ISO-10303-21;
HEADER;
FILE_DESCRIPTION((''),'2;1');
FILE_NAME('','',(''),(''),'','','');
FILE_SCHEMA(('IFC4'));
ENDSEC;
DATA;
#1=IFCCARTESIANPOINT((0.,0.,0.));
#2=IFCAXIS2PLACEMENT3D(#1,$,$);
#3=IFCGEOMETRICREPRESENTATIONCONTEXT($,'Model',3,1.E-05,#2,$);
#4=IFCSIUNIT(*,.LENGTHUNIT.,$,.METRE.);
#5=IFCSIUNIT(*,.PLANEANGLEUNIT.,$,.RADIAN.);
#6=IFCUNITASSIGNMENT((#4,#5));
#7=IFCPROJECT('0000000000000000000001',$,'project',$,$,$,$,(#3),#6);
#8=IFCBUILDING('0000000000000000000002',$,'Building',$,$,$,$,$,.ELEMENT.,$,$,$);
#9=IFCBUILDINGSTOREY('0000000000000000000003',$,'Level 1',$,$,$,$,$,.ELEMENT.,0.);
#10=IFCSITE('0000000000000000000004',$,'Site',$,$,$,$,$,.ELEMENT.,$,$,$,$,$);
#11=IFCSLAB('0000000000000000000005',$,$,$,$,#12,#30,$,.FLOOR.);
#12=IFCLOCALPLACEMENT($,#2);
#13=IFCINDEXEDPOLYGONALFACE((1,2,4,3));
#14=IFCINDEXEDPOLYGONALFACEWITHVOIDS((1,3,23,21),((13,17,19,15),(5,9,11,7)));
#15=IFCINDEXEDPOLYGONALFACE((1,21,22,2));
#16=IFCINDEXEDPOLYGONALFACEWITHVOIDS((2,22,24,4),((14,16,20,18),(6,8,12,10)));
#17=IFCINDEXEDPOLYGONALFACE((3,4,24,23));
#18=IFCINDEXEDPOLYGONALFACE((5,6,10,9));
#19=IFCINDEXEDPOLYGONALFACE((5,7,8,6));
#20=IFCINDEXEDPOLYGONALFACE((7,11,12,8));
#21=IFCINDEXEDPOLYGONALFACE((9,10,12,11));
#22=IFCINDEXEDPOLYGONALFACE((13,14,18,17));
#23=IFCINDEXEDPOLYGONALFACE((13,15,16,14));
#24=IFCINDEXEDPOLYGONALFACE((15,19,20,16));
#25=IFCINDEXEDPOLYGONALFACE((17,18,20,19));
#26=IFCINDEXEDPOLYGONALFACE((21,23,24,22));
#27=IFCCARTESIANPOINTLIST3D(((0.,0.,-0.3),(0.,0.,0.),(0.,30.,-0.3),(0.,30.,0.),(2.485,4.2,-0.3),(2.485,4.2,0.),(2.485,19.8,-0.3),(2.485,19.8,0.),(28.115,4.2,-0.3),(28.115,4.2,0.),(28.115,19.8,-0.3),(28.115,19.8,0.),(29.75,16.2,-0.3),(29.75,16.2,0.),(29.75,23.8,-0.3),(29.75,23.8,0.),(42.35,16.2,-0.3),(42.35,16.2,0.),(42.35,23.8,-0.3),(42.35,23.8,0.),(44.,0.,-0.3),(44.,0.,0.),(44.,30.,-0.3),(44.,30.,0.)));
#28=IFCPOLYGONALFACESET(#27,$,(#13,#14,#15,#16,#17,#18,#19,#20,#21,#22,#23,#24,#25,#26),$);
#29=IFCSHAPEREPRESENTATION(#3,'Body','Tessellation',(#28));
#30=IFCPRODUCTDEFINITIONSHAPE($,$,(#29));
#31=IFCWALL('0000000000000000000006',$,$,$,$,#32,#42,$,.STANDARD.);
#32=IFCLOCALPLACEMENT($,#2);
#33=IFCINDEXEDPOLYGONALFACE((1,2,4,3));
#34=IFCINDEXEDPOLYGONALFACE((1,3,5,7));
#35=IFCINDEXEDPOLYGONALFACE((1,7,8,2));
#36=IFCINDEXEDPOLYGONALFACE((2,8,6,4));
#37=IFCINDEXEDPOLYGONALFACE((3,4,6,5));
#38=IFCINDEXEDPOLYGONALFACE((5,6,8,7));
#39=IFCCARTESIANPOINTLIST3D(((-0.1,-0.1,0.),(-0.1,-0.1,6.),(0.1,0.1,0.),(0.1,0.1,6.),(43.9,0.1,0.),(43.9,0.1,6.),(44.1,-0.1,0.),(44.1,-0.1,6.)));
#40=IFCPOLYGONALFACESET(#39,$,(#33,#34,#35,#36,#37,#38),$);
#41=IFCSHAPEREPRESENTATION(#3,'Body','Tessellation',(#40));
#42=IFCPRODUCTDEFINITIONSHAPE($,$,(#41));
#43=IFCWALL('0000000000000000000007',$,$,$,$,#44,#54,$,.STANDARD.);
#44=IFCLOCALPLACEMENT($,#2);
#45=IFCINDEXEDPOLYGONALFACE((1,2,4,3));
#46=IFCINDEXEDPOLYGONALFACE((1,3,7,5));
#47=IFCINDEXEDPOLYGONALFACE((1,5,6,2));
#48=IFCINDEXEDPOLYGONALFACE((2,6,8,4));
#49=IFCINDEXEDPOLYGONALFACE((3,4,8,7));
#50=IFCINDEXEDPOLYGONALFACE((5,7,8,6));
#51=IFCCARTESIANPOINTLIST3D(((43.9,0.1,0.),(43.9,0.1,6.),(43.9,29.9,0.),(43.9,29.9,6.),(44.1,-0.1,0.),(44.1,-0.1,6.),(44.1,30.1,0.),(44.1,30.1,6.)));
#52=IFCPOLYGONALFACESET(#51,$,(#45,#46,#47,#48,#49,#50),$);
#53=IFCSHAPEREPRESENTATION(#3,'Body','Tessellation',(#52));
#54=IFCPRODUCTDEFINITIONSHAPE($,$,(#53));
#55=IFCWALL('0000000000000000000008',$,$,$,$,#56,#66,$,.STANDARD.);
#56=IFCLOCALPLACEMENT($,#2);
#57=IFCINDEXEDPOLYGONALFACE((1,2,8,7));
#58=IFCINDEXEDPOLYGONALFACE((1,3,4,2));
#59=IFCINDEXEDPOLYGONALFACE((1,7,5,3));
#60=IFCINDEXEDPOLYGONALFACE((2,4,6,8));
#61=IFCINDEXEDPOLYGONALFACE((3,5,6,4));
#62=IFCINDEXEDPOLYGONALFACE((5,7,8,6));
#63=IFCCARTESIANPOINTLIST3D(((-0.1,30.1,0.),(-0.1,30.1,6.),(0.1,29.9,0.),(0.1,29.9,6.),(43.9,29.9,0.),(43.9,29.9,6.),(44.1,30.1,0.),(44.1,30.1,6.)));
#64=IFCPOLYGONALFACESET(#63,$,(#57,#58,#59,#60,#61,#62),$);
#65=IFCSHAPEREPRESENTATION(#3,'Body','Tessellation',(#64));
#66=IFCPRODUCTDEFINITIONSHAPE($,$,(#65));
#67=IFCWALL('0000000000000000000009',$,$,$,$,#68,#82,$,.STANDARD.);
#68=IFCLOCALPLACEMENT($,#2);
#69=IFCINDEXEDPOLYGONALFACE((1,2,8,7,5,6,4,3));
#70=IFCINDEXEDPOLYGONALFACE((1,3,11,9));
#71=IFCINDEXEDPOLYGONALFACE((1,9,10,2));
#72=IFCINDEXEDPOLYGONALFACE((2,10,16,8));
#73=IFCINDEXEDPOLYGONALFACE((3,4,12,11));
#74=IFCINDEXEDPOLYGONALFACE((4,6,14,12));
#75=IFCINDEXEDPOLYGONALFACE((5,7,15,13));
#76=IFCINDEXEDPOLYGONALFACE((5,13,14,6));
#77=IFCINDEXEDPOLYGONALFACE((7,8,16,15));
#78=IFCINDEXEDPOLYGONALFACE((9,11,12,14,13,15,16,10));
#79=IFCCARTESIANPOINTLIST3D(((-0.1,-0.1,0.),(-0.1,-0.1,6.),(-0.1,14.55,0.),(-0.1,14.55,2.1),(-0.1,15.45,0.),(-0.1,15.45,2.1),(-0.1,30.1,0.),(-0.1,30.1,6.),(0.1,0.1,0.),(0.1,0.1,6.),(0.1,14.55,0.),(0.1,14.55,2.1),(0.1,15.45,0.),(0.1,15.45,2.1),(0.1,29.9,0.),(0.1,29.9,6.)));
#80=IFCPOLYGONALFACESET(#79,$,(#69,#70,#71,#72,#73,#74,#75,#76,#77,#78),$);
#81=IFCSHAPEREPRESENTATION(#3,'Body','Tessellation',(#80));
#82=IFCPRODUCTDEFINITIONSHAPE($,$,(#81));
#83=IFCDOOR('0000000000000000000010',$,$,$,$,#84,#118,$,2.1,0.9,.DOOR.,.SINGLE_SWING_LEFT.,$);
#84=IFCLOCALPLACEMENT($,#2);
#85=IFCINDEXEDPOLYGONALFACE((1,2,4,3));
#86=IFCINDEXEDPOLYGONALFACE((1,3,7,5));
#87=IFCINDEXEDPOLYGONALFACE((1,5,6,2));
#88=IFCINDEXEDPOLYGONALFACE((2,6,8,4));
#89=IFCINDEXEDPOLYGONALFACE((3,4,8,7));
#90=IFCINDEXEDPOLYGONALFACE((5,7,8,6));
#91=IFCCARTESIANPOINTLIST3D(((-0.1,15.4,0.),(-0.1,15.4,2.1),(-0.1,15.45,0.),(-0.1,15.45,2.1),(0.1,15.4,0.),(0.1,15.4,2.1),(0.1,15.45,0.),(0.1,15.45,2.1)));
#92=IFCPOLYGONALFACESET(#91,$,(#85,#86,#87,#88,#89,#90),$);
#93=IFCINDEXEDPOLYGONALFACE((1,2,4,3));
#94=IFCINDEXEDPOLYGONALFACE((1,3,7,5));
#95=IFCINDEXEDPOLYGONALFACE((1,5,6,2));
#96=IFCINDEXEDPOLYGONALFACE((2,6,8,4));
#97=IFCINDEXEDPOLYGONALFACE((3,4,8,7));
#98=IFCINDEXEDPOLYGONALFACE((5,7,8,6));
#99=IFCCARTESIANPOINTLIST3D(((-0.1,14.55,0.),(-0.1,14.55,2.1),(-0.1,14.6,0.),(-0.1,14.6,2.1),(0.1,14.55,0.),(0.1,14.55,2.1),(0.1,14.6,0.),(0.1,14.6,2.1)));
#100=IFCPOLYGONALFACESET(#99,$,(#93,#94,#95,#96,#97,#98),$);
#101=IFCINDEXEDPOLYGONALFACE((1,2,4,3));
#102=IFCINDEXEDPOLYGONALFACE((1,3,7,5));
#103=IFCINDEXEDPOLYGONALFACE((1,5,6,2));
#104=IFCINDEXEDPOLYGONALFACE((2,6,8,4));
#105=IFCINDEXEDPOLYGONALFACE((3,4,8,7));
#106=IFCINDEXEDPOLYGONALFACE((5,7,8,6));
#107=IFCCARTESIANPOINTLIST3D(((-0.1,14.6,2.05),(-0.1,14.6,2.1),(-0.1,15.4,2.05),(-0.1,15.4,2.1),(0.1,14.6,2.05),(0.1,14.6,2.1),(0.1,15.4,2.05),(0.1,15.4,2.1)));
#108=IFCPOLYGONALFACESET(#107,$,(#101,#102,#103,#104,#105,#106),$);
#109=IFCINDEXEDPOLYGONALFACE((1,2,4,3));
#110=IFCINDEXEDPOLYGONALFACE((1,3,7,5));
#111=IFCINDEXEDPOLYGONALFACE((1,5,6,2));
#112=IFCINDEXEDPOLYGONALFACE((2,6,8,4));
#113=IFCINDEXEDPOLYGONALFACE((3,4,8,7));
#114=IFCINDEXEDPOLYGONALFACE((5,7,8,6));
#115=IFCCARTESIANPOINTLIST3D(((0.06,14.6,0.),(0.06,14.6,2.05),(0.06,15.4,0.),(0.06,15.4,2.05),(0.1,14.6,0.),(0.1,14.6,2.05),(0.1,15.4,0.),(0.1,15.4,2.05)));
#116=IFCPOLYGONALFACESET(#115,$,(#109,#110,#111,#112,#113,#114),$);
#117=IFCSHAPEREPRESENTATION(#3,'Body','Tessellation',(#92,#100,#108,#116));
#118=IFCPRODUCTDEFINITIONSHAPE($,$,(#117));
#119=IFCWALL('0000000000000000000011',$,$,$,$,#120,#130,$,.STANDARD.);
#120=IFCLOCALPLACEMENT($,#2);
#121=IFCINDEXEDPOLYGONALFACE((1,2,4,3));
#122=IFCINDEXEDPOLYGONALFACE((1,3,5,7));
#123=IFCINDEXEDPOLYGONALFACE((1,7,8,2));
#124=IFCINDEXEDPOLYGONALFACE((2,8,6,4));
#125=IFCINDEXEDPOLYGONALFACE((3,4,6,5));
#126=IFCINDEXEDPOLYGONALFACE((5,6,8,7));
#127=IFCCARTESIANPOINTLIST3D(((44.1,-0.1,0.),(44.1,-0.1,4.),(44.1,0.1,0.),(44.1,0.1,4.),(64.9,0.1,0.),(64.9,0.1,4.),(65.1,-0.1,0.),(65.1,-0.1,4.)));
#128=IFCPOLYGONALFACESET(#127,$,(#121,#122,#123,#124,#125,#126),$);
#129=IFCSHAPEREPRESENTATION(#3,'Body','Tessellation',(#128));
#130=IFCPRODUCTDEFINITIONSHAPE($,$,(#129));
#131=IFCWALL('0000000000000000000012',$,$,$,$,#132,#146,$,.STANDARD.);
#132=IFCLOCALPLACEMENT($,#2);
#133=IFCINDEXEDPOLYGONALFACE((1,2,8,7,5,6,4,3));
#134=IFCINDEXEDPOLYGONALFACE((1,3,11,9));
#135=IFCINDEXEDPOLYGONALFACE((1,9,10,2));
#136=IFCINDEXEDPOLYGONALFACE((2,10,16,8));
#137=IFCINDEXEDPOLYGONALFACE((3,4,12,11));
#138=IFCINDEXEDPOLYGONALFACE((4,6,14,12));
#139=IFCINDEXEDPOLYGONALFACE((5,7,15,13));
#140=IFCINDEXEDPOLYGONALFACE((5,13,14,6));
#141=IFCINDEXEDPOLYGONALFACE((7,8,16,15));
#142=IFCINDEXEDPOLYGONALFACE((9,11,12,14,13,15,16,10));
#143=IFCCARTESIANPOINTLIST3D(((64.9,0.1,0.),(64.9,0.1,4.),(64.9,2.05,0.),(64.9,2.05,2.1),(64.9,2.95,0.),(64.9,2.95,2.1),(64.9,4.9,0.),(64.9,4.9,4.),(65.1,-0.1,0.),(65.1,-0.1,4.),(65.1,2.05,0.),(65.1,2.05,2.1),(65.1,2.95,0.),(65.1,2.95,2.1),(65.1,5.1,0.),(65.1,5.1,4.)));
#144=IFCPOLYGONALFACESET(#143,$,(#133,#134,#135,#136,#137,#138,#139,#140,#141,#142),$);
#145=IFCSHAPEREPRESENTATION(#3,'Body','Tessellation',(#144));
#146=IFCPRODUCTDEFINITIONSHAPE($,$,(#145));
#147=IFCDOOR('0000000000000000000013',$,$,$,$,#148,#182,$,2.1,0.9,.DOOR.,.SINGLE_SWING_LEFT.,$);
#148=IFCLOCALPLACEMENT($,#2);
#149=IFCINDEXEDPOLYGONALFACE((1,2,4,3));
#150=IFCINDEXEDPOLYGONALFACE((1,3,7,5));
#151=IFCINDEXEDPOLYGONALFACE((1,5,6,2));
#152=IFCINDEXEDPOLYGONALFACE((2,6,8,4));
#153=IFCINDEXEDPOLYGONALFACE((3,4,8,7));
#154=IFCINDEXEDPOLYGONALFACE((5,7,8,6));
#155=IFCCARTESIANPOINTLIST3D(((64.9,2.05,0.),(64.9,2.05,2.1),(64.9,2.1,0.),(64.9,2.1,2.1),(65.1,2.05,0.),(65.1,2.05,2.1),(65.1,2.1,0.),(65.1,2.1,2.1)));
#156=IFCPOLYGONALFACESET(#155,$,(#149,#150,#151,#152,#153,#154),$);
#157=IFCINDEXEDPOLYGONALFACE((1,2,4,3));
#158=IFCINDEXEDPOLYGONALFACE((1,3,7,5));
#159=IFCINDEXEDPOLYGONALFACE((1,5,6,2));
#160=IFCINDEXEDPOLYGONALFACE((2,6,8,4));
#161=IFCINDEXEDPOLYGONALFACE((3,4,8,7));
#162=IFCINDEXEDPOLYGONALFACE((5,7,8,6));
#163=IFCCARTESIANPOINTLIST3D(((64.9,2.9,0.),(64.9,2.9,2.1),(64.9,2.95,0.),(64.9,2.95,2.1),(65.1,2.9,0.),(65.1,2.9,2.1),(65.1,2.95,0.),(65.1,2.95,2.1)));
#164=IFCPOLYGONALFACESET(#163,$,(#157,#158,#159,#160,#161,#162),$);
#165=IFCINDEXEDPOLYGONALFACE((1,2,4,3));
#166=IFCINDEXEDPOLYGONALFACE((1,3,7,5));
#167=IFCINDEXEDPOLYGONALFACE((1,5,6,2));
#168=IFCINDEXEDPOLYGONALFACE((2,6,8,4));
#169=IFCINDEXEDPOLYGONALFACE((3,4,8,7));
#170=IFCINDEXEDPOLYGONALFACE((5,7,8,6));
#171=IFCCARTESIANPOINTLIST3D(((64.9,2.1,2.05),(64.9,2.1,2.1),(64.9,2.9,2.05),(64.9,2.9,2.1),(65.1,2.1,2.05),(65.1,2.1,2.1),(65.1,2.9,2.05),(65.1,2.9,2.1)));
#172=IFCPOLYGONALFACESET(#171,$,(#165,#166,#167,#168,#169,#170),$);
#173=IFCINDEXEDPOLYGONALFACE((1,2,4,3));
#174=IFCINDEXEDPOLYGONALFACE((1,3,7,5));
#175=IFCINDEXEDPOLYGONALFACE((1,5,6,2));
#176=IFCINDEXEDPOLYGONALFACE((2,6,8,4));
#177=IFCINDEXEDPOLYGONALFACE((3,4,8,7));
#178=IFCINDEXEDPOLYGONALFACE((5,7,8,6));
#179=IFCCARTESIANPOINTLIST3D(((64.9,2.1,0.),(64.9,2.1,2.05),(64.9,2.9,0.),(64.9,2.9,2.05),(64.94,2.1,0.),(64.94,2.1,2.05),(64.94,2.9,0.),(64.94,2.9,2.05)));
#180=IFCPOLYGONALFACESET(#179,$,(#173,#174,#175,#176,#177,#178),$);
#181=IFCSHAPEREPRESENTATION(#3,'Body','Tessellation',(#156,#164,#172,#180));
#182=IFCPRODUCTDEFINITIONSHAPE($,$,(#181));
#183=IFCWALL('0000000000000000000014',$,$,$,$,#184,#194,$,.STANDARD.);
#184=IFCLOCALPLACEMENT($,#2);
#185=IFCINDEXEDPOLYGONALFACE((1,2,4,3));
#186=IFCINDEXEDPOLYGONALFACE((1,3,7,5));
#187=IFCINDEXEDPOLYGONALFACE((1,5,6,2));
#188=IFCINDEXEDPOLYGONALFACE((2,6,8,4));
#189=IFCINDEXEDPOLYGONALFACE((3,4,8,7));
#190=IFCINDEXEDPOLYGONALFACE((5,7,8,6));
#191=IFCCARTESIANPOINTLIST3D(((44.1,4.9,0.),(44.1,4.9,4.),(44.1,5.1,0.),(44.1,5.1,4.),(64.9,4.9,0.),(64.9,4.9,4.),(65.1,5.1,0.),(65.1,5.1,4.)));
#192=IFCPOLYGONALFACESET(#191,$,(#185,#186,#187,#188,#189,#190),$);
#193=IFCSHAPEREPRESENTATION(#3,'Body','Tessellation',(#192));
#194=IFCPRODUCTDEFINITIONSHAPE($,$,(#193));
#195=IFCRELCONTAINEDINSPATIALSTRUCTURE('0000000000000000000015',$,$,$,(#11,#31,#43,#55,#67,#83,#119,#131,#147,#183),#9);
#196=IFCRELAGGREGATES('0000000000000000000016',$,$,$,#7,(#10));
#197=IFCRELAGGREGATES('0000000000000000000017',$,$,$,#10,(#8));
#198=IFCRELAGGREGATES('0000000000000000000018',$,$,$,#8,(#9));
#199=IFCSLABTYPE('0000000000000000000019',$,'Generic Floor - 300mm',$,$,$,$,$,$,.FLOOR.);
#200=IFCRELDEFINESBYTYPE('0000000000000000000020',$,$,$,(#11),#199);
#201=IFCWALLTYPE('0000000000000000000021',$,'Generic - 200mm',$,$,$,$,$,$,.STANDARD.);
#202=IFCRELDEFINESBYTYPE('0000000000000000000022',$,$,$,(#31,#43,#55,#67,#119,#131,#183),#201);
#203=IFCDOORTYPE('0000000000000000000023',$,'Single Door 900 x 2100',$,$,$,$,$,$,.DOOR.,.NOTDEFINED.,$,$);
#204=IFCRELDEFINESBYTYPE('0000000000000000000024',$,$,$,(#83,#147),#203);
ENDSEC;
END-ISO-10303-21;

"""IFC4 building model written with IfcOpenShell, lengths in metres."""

from ifc_helpers import new_model, si_unit, frame, frame_2d, origin, origin_with_axes, origin_2d, place, context, project, spatial, polyline, rectangle, outline, extrude, type_object, element, fill, save


model = new_model("IFC4")

# Units and contexts
model_context = context("Model", 3, precision=1e-05, world=origin())
ifc_project = project(units=[si_unit("LENGTHUNIT", "METRE"), si_unit("PLANEANGLEUNIT", "RADIAN")], contexts=[model_context])

# Site, building, storey
site = spatial("IfcSite", under=ifc_project, Name="Site", CompositionType="ELEMENT")
building = spatial("IfcBuilding", under=site, Name="Building", CompositionType="ELEMENT")
storey = spatial("IfcBuildingStorey", under=building, Name="Level 1", CompositionType="ELEMENT", Elevation=0.0)

# Slab, openings
slab_type = type_object("IfcSlabType", Name="Generic Floor - 300mm", PredefinedType="FLOOR")
slab_placement = place(None, origin())
slab = element("IfcSlab", 1, at=slab_placement, inside=storey, type_object=slab_type, PredefinedType="FLOOR", context=model_context, shape_type="SweptSolid", body=[
    extrude(outline(polyline([(0.0, 0.0), (44.0, 0.0), (44.0, 30.0), (0.0, 30.0), (0.0, 0.0)])), origin(), (0.0, 0.0, -1.0), 0.3),
])
opening_1_placement = place(None, frame((0.0, 0.0, 0.001)))
element("IfcOpeningElement", 2, at=opening_1_placement, cuts=slab, PredefinedType="OPENING", context=model_context, shape_type="SweptSolid", body=[
    extrude(outline(polyline([(2.485, 19.8), (2.485, 4.2), (28.115, 4.2), (28.115, 19.8), (2.485, 19.8)])), origin(), (0.0, 0.0, -1.0), 0.302),
])
opening_2_placement = place(None, frame((0.0, 0.0, 0.001)))
element("IfcOpeningElement", 3, at=opening_2_placement, cuts=slab, PredefinedType="OPENING", context=model_context, shape_type="SweptSolid", body=[
    extrude(outline(polyline([(29.75, 23.8), (29.75, 16.2), (42.35, 16.2), (42.35, 23.8), (29.75, 23.8)])), origin(), (0.0, 0.0, -1.0), 0.302),
])

# Walls
wall_type = type_object("IfcWallType", Name="Generic - 200mm", PredefinedType="STANDARD")
wall_1_placement = place(None, origin_with_axes())
element("IfcWall", 4, at=wall_1_placement, inside=storey, type_object=wall_type, PredefinedType="STANDARD", context=model_context, shape_type="SweptSolid", body=[
    extrude(outline(polyline([(-0.1, -0.1), (44.1, -0.1), (43.9, 0.1), (0.1, 0.1), (-0.1, -0.1)])), origin(), (0.0, 0.0, 1.0), 6.0),
])
wall_2_placement = place(None, frame((44.0, 0.0, 0.0), z_axis=(0.0, 0.0, 1.0), x_axis=(0.0, 1.0, 0.0)))
element("IfcWall", 5, at=wall_2_placement, inside=storey, type_object=wall_type, PredefinedType="STANDARD", context=model_context, shape_type="SweptSolid", body=[
    extrude(outline(polyline([(-0.1, -0.1), (30.1, -0.1), (29.9, 0.1), (0.1, 0.1), (-0.1, -0.1)])), origin(), (0.0, 0.0, 1.0), 6.0),
])
wall_3_placement = place(None, frame((44.0, 30.0, 0.0), z_axis=(0.0, 0.0, 1.0), x_axis=(-1.0, 0.0, 0.0)))
element("IfcWall", 6, at=wall_3_placement, inside=storey, type_object=wall_type, PredefinedType="STANDARD", context=model_context, shape_type="SweptSolid", body=[
    extrude(outline(polyline([(-0.1, -0.1), (44.1, -0.1), (43.9, 0.1), (0.1, 0.1), (-0.1, -0.1)])), origin(), (0.0, 0.0, 1.0), 6.0),
])

# Wall, opening, door
wall_4_placement = place(None, frame((0.0, 30.0, 0.0), z_axis=(0.0, 0.0, 1.0), x_axis=(0.0, -1.0, 0.0)))
wall_4 = element("IfcWall", 7, at=wall_4_placement, inside=storey, type_object=wall_type, PredefinedType="STANDARD", context=model_context, shape_type="SweptSolid", body=[
    extrude(outline(polyline([(-0.1, -0.1), (30.1, -0.1), (29.9, 0.1), (0.1, 0.1), (-0.1, -0.1)])), origin(), (0.0, 0.0, 1.0), 6.0),
])
opening_3_placement = place(wall_4_placement, frame((15.0, 0.0, 0.0), z_axis=(0.0, 0.0, 1.0), x_axis=(1.0, 0.0, 0.0)))
opening_3 = element("IfcOpeningElement", 8, at=opening_3_placement, cuts=wall_4, PredefinedType="OPENING", context=model_context, shape_type="SweptSolid", body=[
    extrude(rectangle(XDim=0.9, YDim=0.202, at=origin_2d()), origin(), (0.0, 0.0, 1.0), 2.1),
])
door_type = type_object("IfcDoorType", Name="Single Door 900 x 2100", OperationType="NOTDEFINED", PredefinedType="DOOR")
door_1_placement = place(opening_3_placement, origin_with_axes())
door_1 = element("IfcDoor", 9, at=door_1_placement, inside=storey, type_object=door_type, OperationType="SINGLE_SWING_LEFT", OverallHeight=2.1, OverallWidth=0.9, PredefinedType="DOOR", context=model_context, shape_type="SweptSolid", body=[
    extrude(rectangle(XDim=0.05, YDim=0.2, at=frame_2d((-0.425, 0.0))), origin(), (0.0, 0.0, 1.0), 2.1),
    extrude(rectangle(XDim=0.05, YDim=0.2, at=frame_2d((0.425, 0.0))), origin(), (0.0, 0.0, 1.0), 2.1),
    extrude(rectangle(XDim=0.8, YDim=0.2, at=origin_2d()), frame((0.0, 0.0, 2.05)), (0.0, 0.0, 1.0), 0.05),
    extrude(rectangle(XDim=0.8, YDim=0.04, at=frame_2d((0.0, 0.08))), origin(), (0.0, 0.0, 1.0), 2.05),
])
fill(opening_3, door_1)

# Wall
wall_5_placement = place(None, frame((44.1, 0.0, 0.0), z_axis=(0.0, 0.0, 1.0), x_axis=(1.0, 0.0, 0.0)))
element("IfcWall", 10, at=wall_5_placement, inside=storey, type_object=wall_type, PredefinedType="STANDARD", context=model_context, shape_type="SweptSolid", body=[
    extrude(outline(polyline([(0.0, -0.1), (21.0, -0.1), (20.8, 0.1), (0.0, 0.1), (0.0, -0.1)])), origin(), (0.0, 0.0, 1.0), 4.0),
])

# Wall, opening, door
wall_6_placement = place(None, frame((65.0, 0.0, 0.0), z_axis=(0.0, 0.0, 1.0), x_axis=(0.0, 1.0, 0.0)))
wall_6 = element("IfcWall", 11, at=wall_6_placement, inside=storey, type_object=wall_type, PredefinedType="STANDARD", context=model_context, shape_type="SweptSolid", body=[
    extrude(outline(polyline([(-0.1, -0.1), (5.1, -0.1), (4.9, 0.1), (0.1, 0.1), (-0.1, -0.1)])), origin(), (0.0, 0.0, 1.0), 4.0),
])
opening_4_placement = place(wall_6_placement, frame((2.5, 0.0, 0.0), z_axis=(0.0, 0.0, 1.0), x_axis=(1.0, 0.0, 0.0)))
opening_4 = element("IfcOpeningElement", 12, at=opening_4_placement, cuts=wall_6, PredefinedType="OPENING", context=model_context, shape_type="SweptSolid", body=[
    extrude(rectangle(XDim=0.9, YDim=0.202, at=origin_2d()), origin(), (0.0, 0.0, 1.0), 2.1),
])
door_2_placement = place(opening_4_placement, origin_with_axes())
door_2 = element("IfcDoor", 13, at=door_2_placement, inside=storey, type_object=door_type, OperationType="SINGLE_SWING_LEFT", OverallHeight=2.1, OverallWidth=0.9, PredefinedType="DOOR", context=model_context, shape_type="SweptSolid", body=[
    extrude(rectangle(XDim=0.05, YDim=0.2, at=frame_2d((-0.425, 0.0))), origin(), (0.0, 0.0, 1.0), 2.1),
    extrude(rectangle(XDim=0.05, YDim=0.2, at=frame_2d((0.425, 0.0))), origin(), (0.0, 0.0, 1.0), 2.1),
    extrude(rectangle(XDim=0.8, YDim=0.2, at=origin_2d()), frame((0.0, 0.0, 2.05)), (0.0, 0.0, 1.0), 0.05),
    extrude(rectangle(XDim=0.8, YDim=0.04, at=frame_2d((0.0, 0.08))), origin(), (0.0, 0.0, 1.0), 2.05),
])
fill(opening_4, door_2)

# Wall
wall_7_placement = place(None, frame((65.0, 5.0, 0.0), z_axis=(0.0, 0.0, 1.0), x_axis=(-1.0, 0.0, 0.0)))
element("IfcWall", 14, at=wall_7_placement, inside=storey, type_object=wall_type, PredefinedType="STANDARD", context=model_context, shape_type="SweptSolid", body=[
    extrude(outline(polyline([(-0.1, -0.1), (20.9, -0.1), (20.9, 0.1), (0.1, 0.1), (-0.1, -0.1)])), origin(), (0.0, 0.0, 1.0), 4.0),
])

save(model, "model.ifc")
